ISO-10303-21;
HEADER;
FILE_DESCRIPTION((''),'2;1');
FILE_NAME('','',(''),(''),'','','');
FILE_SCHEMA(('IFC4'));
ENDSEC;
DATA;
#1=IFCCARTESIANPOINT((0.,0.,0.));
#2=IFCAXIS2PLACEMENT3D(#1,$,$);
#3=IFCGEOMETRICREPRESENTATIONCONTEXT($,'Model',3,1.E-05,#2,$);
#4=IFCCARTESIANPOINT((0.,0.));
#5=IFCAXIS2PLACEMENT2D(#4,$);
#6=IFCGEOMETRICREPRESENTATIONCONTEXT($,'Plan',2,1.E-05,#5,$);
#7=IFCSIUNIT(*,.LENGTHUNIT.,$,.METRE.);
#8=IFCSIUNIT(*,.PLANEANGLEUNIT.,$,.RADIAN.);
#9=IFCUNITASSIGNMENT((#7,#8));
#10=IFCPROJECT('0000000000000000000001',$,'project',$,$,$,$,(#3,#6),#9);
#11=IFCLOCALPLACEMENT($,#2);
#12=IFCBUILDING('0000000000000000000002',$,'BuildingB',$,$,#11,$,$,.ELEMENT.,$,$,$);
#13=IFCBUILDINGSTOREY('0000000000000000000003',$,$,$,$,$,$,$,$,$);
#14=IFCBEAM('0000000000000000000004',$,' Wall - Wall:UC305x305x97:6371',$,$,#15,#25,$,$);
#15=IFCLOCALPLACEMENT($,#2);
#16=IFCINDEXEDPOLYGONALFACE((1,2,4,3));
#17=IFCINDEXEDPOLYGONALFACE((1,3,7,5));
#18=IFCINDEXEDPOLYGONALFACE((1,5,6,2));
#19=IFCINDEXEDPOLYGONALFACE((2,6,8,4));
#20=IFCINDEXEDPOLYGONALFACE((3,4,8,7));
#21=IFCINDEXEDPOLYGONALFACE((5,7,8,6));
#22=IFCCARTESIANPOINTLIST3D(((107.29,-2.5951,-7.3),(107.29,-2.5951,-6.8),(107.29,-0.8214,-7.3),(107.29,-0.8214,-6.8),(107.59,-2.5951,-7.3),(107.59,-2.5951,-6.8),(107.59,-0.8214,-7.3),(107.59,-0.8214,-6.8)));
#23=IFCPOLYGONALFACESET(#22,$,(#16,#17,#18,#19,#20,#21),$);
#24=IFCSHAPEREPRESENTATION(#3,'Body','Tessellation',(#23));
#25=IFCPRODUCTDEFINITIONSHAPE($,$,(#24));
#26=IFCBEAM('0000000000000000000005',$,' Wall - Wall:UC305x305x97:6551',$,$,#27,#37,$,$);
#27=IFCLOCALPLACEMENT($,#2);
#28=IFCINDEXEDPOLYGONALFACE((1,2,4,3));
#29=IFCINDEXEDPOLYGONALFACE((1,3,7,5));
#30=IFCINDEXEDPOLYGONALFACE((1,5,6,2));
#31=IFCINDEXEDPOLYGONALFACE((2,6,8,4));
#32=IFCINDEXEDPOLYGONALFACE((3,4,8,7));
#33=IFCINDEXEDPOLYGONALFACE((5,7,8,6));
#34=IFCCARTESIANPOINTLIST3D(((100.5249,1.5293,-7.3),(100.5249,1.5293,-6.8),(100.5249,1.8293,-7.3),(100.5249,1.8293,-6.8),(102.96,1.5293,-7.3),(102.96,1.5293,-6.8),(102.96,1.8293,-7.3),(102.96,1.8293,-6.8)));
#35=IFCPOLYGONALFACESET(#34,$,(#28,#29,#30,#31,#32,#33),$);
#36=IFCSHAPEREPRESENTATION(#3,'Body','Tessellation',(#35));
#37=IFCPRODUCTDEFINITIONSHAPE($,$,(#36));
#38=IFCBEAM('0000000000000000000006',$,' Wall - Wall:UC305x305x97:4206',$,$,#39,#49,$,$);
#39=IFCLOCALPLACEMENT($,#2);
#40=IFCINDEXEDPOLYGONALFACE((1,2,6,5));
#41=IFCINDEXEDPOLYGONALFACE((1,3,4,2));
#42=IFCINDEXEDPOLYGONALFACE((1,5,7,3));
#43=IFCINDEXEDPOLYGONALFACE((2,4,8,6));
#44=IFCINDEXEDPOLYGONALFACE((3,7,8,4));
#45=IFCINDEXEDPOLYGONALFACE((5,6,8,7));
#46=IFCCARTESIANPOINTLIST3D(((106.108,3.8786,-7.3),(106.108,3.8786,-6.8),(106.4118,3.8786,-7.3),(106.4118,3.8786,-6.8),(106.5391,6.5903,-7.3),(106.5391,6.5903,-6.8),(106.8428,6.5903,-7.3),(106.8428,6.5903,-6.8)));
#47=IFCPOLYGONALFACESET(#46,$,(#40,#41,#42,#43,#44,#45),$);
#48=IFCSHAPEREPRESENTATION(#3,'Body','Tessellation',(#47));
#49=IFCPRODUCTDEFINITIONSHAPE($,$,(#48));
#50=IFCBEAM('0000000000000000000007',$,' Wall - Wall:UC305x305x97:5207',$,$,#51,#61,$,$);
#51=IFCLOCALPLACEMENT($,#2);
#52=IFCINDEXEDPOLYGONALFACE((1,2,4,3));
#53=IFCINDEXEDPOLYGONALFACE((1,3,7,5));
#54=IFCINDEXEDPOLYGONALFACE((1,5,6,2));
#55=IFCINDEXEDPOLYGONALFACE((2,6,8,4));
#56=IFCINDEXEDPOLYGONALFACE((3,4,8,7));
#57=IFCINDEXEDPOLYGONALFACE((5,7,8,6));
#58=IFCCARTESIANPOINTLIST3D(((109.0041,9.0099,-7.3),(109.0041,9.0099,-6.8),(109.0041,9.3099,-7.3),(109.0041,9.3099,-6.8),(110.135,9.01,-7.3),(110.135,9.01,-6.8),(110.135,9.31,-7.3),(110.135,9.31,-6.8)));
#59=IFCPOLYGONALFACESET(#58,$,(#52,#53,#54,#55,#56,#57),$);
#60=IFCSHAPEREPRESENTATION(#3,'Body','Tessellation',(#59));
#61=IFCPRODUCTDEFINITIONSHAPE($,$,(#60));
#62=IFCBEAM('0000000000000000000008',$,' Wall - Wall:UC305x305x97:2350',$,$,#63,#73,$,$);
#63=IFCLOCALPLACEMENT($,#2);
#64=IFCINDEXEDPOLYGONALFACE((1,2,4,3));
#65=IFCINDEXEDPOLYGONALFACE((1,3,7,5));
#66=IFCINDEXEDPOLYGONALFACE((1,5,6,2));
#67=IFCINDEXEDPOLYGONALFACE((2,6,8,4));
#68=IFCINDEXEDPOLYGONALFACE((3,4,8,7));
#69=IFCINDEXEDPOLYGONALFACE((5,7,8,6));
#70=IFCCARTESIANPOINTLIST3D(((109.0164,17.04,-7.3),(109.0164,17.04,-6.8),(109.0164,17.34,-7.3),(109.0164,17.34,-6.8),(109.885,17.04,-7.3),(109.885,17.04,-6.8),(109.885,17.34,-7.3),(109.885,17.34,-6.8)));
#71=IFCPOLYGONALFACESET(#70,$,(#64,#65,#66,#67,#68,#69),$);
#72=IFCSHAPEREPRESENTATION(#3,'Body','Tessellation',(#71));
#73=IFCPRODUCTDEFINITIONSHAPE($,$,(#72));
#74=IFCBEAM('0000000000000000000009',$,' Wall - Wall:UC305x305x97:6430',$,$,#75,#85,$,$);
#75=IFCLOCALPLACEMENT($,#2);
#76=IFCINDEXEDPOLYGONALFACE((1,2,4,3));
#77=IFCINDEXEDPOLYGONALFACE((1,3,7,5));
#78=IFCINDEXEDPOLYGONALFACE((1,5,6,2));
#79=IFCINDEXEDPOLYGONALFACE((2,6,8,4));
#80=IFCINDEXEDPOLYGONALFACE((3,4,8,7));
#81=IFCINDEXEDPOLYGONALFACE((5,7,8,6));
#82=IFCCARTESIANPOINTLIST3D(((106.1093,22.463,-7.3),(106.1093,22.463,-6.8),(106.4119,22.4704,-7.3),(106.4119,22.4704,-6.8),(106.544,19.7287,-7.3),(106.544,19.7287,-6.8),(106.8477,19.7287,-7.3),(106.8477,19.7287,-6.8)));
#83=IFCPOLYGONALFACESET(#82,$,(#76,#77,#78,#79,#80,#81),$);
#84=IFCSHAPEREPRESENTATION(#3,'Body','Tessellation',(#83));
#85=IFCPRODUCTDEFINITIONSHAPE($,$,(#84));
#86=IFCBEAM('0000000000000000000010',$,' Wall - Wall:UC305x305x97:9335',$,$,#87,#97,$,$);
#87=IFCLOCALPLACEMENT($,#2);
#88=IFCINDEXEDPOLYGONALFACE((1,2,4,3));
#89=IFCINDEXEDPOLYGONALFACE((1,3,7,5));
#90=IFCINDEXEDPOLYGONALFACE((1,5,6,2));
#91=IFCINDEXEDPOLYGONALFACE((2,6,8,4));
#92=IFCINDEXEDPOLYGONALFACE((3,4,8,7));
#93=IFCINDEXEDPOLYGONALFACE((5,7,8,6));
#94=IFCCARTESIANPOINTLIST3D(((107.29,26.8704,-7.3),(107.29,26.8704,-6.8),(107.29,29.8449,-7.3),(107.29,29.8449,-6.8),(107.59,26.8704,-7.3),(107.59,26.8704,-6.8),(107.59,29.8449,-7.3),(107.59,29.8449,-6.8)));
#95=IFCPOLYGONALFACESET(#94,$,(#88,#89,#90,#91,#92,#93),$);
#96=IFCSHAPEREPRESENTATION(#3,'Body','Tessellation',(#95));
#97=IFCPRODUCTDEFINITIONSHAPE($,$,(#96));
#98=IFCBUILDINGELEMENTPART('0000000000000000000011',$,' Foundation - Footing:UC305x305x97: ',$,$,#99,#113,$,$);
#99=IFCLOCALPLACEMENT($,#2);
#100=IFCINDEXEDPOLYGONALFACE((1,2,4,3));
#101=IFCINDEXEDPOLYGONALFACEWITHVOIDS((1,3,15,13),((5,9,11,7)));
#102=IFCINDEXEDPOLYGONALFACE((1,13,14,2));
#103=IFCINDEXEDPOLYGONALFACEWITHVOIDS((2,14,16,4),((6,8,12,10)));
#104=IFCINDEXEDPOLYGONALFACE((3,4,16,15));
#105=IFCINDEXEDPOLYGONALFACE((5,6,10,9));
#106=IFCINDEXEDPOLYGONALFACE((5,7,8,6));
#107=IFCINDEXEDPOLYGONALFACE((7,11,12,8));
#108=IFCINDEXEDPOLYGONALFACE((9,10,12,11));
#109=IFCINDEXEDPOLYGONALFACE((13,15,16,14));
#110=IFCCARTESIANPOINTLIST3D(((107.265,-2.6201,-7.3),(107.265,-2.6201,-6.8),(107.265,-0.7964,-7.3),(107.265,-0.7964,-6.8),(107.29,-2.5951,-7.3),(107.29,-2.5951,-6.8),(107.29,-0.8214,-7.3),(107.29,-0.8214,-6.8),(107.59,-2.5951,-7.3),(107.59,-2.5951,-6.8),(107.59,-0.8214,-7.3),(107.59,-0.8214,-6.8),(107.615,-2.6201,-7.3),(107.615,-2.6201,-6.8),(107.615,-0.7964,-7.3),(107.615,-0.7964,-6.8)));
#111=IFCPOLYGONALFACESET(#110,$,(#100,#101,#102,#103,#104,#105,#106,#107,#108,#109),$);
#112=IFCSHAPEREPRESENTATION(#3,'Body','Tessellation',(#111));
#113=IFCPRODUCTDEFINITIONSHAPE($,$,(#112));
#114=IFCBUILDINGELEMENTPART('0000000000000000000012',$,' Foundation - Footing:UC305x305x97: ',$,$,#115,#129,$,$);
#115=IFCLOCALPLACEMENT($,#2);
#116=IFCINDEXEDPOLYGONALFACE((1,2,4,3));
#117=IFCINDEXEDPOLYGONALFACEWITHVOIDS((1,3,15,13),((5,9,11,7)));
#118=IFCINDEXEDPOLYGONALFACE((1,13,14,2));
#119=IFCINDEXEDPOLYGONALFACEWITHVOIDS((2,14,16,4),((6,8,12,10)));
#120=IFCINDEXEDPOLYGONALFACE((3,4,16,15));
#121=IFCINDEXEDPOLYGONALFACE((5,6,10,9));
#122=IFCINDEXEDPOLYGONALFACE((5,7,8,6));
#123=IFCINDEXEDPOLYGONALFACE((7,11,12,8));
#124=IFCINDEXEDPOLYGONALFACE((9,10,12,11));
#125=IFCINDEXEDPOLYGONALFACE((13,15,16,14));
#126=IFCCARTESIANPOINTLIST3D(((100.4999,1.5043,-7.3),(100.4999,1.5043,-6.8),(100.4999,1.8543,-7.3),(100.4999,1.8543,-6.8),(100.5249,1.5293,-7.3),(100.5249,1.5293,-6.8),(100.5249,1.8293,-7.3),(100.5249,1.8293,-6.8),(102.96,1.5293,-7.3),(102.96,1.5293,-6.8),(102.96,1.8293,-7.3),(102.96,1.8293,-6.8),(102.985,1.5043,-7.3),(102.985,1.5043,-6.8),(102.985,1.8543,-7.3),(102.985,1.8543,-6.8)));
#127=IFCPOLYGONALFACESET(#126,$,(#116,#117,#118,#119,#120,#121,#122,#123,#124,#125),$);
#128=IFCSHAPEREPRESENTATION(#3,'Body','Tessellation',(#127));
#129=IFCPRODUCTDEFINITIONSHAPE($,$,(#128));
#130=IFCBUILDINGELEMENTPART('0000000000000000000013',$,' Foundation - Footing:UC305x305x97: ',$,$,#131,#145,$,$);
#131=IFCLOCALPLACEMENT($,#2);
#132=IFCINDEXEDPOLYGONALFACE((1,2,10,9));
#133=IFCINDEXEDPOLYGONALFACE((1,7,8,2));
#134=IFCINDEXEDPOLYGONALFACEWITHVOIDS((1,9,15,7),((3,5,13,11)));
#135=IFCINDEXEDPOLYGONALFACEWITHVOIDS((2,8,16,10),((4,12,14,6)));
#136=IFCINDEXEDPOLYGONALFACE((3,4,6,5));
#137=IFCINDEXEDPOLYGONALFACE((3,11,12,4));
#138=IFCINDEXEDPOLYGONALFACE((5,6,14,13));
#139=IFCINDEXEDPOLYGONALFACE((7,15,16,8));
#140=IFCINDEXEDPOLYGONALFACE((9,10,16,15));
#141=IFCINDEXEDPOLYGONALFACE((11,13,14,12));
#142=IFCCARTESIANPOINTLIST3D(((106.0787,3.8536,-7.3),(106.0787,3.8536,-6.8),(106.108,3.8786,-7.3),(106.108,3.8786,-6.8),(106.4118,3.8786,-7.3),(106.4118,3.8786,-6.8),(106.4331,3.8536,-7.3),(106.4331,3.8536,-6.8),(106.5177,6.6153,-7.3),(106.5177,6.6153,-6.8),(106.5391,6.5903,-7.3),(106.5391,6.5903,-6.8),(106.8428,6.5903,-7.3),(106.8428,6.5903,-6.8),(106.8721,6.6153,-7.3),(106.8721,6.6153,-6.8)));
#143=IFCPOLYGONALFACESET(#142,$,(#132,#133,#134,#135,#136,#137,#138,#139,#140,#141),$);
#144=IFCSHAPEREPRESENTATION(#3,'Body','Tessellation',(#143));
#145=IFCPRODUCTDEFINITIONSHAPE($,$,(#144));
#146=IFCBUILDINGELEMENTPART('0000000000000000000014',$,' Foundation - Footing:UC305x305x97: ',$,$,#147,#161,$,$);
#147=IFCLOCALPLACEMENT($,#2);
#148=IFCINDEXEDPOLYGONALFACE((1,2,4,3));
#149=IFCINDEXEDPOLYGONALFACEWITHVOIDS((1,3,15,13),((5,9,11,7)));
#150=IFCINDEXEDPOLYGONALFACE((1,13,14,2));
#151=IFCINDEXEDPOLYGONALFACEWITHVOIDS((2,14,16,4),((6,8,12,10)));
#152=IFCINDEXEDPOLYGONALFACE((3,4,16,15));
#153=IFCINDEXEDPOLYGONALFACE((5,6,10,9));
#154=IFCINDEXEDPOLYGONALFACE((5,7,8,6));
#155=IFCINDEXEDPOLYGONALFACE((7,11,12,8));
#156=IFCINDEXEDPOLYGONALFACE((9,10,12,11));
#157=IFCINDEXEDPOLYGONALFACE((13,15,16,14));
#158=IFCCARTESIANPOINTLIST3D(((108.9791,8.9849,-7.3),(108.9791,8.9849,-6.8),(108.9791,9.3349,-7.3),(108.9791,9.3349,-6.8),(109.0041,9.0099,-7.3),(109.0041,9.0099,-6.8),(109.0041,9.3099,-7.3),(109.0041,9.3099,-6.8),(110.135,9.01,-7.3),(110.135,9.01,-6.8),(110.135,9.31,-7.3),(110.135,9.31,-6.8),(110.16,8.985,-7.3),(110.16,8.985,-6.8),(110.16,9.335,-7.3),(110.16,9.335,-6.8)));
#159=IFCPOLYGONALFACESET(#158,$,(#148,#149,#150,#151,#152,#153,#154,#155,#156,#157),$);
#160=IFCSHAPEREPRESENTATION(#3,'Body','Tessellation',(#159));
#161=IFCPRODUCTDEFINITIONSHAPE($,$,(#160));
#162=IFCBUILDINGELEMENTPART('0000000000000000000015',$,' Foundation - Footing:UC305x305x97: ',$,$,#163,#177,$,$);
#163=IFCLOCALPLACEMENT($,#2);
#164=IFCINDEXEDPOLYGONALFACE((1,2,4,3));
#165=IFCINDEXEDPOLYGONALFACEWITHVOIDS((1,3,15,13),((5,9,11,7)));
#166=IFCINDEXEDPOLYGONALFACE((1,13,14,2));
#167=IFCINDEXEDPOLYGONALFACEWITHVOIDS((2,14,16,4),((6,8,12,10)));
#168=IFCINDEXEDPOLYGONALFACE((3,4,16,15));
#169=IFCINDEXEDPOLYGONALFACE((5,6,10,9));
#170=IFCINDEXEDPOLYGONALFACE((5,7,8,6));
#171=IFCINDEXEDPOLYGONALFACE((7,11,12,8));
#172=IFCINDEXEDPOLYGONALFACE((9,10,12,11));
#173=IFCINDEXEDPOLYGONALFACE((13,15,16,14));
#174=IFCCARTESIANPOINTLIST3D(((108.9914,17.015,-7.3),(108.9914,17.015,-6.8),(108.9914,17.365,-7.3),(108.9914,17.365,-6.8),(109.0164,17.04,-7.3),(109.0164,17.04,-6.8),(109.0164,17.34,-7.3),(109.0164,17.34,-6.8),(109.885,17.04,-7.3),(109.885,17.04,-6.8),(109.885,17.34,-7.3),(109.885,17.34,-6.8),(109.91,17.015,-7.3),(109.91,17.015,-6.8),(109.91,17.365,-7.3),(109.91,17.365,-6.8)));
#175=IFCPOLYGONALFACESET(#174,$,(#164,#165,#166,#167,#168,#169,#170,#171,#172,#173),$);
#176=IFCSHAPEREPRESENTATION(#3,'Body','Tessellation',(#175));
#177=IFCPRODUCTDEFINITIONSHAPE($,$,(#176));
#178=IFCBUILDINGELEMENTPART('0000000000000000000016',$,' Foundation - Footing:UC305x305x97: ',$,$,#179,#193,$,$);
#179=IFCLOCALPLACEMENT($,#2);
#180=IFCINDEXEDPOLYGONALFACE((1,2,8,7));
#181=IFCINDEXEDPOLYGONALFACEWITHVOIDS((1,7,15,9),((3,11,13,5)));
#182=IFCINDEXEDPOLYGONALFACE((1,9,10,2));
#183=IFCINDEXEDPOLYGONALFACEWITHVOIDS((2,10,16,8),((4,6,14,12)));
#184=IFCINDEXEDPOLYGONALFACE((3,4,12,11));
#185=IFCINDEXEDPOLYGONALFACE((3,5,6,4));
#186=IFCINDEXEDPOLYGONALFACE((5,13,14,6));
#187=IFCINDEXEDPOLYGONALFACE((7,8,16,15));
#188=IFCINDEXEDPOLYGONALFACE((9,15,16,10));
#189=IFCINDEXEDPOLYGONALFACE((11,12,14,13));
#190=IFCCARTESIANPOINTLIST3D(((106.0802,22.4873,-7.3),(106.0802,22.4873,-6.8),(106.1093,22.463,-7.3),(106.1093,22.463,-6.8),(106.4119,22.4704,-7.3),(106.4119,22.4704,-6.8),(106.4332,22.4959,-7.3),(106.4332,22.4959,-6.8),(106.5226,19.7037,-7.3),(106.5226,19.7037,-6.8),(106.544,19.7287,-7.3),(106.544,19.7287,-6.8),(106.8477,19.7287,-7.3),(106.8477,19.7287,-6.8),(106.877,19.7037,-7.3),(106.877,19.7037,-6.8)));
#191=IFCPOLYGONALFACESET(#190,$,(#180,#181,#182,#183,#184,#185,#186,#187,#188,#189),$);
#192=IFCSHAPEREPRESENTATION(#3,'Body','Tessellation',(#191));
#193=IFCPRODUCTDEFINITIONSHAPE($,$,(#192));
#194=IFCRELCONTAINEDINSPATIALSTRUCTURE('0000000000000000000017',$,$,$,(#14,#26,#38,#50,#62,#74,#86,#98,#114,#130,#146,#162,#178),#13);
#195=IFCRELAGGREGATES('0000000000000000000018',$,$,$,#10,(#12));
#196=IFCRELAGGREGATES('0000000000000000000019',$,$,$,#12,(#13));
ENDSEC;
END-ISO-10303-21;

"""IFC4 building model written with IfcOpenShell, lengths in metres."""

from ifc_helpers import new_model, si_unit, origin, origin_2d, place, context, project, spatial, polyline, outline, extrude, element, save


model = new_model("IFC4")

# Units and contexts
model_context = context("Model", 3, precision=1e-05, world=origin())
plan_context = context("Plan", 2, precision=1e-05, world=origin_2d())
ifc_project = project(units=[si_unit("LENGTHUNIT", "METRE"), si_unit("PLANEANGLEUNIT", "RADIAN")], contexts=[model_context, plan_context])

# Building, storey
building_placement = place(None, origin())
building = spatial("IfcBuilding", under=ifc_project, at=building_placement, Name="BuildingB", CompositionType="ELEMENT")
storey = spatial("IfcBuildingStorey", under=building)

# Beams
element("IfcBeam", 1, inside=storey, Name=" Wall - Wall:UC305x305x97:6371", context=model_context, shape_type="SweptSolid", body=[
    extrude(outline(polyline([(107.59, -2.5951, -7.3), (107.29, -2.5951, -7.3), (107.29, -0.8214, -7.3), (107.59, -0.8214, -7.3), (107.59, -2.5951, -7.3)])), None, (0.0, 0.0, 1.0), 0.5),
])
element("IfcBeam", 2, inside=storey, Name=" Wall - Wall:UC305x305x97:6551", context=model_context, shape_type="SweptSolid", body=[
    extrude(outline(polyline([(102.96, 1.5293, -7.3), (102.96, 1.8293, -7.3), (100.5249, 1.8293, -7.3), (100.5249, 1.5293, -7.3), (102.96, 1.5293, -7.3)])), None, (0.0, 0.0, 1.0), 0.5),
])
element("IfcBeam", 3, inside=storey, Name=" Wall - Wall:UC305x305x97:4206", context=model_context, shape_type="SweptSolid", body=[
    extrude(outline(polyline([(106.4118, 3.8786, -7.3), (106.8428, 6.5903, -7.3), (106.5391, 6.5903, -7.3), (106.108, 3.8786, -7.3), (106.4118, 3.8786, -7.3)])), None, (0.0, 0.0, 1.0), 0.5),
])
element("IfcBeam", 4, inside=storey, Name=" Wall - Wall:UC305x305x97:5207", context=model_context, shape_type="SweptSolid", body=[
    extrude(outline(polyline([(110.135, 9.01, -7.3), (110.135, 9.31, -7.3), (109.0041, 9.3099, -7.3), (109.0041, 9.0099, -7.3), (110.135, 9.01, -7.3)])), None, (0.0, 0.0, 1.0), 0.5),
])
element("IfcBeam", 5, inside=storey, Name=" Wall - Wall:UC305x305x97:2350", context=model_context, shape_type="SweptSolid", body=[
    extrude(outline(polyline([(109.885, 17.04, -7.3), (109.885, 17.34, -7.3), (109.0164, 17.34, -7.3), (109.0164, 17.04, -7.3), (109.885, 17.04, -7.3)])), None, (0.0, 0.0, 1.0), 0.5),
])
element("IfcBeam", 6, inside=storey, Name=" Wall - Wall:UC305x305x97:6430", context=model_context, shape_type="SweptSolid", body=[
    extrude(outline(polyline([(106.544, 19.7287, -7.3), (106.8477, 19.7287, -7.3), (106.4119, 22.4704, -7.3), (106.1093, 22.463, -7.3), (106.544, 19.7287, -7.3)])), None, (0.0, 0.0, 1.0), 0.5),
])
element("IfcBeam", 7, inside=storey, Name=" Wall - Wall:UC305x305x97:9335", context=model_context, shape_type="SweptSolid", body=[
    extrude(outline(polyline([(107.29, 26.8704, -7.3), (107.59, 26.8704, -7.3), (107.59, 29.8449, -7.3), (107.29, 29.8449, -7.3), (107.29, 26.8704, -7.3)])), None, (0.0, 0.0, 1.0), 0.5),
])

# Building element parts, openings
building_element_part_1 = element("IfcBuildingElementPart", 8, inside=storey, Name=" Foundation - Footing:UC305x305x97: ", context=model_context, shape_type="SweptSolid", body=[
    extrude(outline(polyline([(107.615, -2.6201, -7.3), (107.265, -2.6201, -7.3), (107.265, -0.7964, -7.3), (107.615, -0.7964, -7.3), (107.615, -2.6201, -7.3)])), None, (0.0, 0.0, 1.0), 0.5),
])
element("IfcOpeningElement", 9, inside=storey, cuts=building_element_part_1, context=model_context, shape_type="SweptSolid", body=[
    extrude(outline(polyline([(107.59, -2.5951, -7.3), (107.29, -2.5951, -7.3), (107.29, -0.8214, -7.3), (107.59, -0.8214, -7.3), (107.59, -2.5951, -7.3)])), None, (0.0, 0.0, 1.0), 0.5),
])
building_element_part_2 = element("IfcBuildingElementPart", 10, inside=storey, Name=" Foundation - Footing:UC305x305x97: ", context=model_context, shape_type="SweptSolid", body=[
    extrude(outline(polyline([(102.985, 1.5043, -7.3), (102.985, 1.8543, -7.3), (100.4999, 1.8543, -7.3), (100.4999, 1.5043, -7.3), (102.985, 1.5043, -7.3)])), None, (0.0, 0.0, 1.0), 0.5),
])
element("IfcOpeningElement", 11, inside=storey, cuts=building_element_part_2, context=model_context, shape_type="SweptSolid", body=[
    extrude(outline(polyline([(102.96, 1.5293, -7.3), (102.96, 1.8293, -7.3), (100.5249, 1.8293, -7.3), (100.5249, 1.5293, -7.3), (102.96, 1.5293, -7.3)])), None, (0.0, 0.0, 1.0), 0.5),
])
building_element_part_3 = element("IfcBuildingElementPart", 12, inside=storey, Name=" Foundation - Footing:UC305x305x97: ", context=model_context, shape_type="SweptSolid", body=[
    extrude(outline(polyline([(106.4331, 3.8536, -7.3), (106.8721, 6.6153, -7.3), (106.5177, 6.6153, -7.3), (106.0787, 3.8536, -7.3), (106.4331, 3.8536, -7.3)])), None, (0.0, 0.0, 1.0), 0.5),
])
element("IfcOpeningElement", 13, inside=storey, cuts=building_element_part_3, context=model_context, shape_type="SweptSolid", body=[
    extrude(outline(polyline([(106.4118, 3.8786, -7.3), (106.8428, 6.5903, -7.3), (106.5391, 6.5903, -7.3), (106.108, 3.8786, -7.3), (106.4118, 3.8786, -7.3)])), None, (0.0, 0.0, 1.0), 0.5),
])
building_element_part_4 = element("IfcBuildingElementPart", 14, inside=storey, Name=" Foundation - Footing:UC305x305x97: ", context=model_context, shape_type="SweptSolid", body=[
    extrude(outline(polyline([(110.16, 8.985, -7.3), (110.16, 9.335, -7.3), (108.9791, 9.3349, -7.3), (108.9791, 8.9849, -7.3), (110.16, 8.985, -7.3)])), None, (0.0, 0.0, 1.0), 0.5),
])
element("IfcOpeningElement", 15, inside=storey, cuts=building_element_part_4, context=model_context, shape_type="SweptSolid", body=[
    extrude(outline(polyline([(110.135, 9.01, -7.3), (110.135, 9.31, -7.3), (109.0041, 9.3099, -7.3), (109.0041, 9.0099, -7.3), (110.135, 9.01, -7.3)])), None, (0.0, 0.0, 1.0), 0.5),
])
building_element_part_5 = element("IfcBuildingElementPart", 16, inside=storey, Name=" Foundation - Footing:UC305x305x97: ", context=model_context, shape_type="SweptSolid", body=[
    extrude(outline(polyline([(109.91, 17.015, -7.3), (109.91, 17.365, -7.3), (108.9914, 17.365, -7.3), (108.9914, 17.015, -7.3), (109.91, 17.015, -7.3)])), None, (0.0, 0.0, 1.0), 0.5),
])
element("IfcOpeningElement", 17, inside=storey, cuts=building_element_part_5, context=model_context, shape_type="SweptSolid", body=[
    extrude(outline(polyline([(109.885, 17.04, -7.3), (109.885, 17.34, -7.3), (109.0164, 17.34, -7.3), (109.0164, 17.04, -7.3), (109.885, 17.04, -7.3)])), None, (0.0, 0.0, 1.0), 0.5),
])
building_element_part_6 = element("IfcBuildingElementPart", 18, inside=storey, Name=" Foundation - Footing:UC305x305x97: ", context=model_context, shape_type="SweptSolid", body=[
    extrude(outline(polyline([(106.5226, 19.7037, -7.3), (106.877, 19.7037, -7.3), (106.4332, 22.4959, -7.3), (106.0802, 22.4873, -7.3), (106.5226, 19.7037, -7.3)])), None, (0.0, 0.0, 1.0), 0.5),
])
element("IfcOpeningElement", 19, inside=storey, cuts=building_element_part_6, context=model_context, shape_type="SweptSolid", body=[
    extrude(outline(polyline([(106.544, 19.7287, -7.3), (106.8477, 19.7287, -7.3), (106.4119, 22.4704, -7.3), (106.1093, 22.463, -7.3), (106.544, 19.7287, -7.3)])), None, (0.0, 0.0, 1.0), 0.5),
])

save(model, "model.ifc")
